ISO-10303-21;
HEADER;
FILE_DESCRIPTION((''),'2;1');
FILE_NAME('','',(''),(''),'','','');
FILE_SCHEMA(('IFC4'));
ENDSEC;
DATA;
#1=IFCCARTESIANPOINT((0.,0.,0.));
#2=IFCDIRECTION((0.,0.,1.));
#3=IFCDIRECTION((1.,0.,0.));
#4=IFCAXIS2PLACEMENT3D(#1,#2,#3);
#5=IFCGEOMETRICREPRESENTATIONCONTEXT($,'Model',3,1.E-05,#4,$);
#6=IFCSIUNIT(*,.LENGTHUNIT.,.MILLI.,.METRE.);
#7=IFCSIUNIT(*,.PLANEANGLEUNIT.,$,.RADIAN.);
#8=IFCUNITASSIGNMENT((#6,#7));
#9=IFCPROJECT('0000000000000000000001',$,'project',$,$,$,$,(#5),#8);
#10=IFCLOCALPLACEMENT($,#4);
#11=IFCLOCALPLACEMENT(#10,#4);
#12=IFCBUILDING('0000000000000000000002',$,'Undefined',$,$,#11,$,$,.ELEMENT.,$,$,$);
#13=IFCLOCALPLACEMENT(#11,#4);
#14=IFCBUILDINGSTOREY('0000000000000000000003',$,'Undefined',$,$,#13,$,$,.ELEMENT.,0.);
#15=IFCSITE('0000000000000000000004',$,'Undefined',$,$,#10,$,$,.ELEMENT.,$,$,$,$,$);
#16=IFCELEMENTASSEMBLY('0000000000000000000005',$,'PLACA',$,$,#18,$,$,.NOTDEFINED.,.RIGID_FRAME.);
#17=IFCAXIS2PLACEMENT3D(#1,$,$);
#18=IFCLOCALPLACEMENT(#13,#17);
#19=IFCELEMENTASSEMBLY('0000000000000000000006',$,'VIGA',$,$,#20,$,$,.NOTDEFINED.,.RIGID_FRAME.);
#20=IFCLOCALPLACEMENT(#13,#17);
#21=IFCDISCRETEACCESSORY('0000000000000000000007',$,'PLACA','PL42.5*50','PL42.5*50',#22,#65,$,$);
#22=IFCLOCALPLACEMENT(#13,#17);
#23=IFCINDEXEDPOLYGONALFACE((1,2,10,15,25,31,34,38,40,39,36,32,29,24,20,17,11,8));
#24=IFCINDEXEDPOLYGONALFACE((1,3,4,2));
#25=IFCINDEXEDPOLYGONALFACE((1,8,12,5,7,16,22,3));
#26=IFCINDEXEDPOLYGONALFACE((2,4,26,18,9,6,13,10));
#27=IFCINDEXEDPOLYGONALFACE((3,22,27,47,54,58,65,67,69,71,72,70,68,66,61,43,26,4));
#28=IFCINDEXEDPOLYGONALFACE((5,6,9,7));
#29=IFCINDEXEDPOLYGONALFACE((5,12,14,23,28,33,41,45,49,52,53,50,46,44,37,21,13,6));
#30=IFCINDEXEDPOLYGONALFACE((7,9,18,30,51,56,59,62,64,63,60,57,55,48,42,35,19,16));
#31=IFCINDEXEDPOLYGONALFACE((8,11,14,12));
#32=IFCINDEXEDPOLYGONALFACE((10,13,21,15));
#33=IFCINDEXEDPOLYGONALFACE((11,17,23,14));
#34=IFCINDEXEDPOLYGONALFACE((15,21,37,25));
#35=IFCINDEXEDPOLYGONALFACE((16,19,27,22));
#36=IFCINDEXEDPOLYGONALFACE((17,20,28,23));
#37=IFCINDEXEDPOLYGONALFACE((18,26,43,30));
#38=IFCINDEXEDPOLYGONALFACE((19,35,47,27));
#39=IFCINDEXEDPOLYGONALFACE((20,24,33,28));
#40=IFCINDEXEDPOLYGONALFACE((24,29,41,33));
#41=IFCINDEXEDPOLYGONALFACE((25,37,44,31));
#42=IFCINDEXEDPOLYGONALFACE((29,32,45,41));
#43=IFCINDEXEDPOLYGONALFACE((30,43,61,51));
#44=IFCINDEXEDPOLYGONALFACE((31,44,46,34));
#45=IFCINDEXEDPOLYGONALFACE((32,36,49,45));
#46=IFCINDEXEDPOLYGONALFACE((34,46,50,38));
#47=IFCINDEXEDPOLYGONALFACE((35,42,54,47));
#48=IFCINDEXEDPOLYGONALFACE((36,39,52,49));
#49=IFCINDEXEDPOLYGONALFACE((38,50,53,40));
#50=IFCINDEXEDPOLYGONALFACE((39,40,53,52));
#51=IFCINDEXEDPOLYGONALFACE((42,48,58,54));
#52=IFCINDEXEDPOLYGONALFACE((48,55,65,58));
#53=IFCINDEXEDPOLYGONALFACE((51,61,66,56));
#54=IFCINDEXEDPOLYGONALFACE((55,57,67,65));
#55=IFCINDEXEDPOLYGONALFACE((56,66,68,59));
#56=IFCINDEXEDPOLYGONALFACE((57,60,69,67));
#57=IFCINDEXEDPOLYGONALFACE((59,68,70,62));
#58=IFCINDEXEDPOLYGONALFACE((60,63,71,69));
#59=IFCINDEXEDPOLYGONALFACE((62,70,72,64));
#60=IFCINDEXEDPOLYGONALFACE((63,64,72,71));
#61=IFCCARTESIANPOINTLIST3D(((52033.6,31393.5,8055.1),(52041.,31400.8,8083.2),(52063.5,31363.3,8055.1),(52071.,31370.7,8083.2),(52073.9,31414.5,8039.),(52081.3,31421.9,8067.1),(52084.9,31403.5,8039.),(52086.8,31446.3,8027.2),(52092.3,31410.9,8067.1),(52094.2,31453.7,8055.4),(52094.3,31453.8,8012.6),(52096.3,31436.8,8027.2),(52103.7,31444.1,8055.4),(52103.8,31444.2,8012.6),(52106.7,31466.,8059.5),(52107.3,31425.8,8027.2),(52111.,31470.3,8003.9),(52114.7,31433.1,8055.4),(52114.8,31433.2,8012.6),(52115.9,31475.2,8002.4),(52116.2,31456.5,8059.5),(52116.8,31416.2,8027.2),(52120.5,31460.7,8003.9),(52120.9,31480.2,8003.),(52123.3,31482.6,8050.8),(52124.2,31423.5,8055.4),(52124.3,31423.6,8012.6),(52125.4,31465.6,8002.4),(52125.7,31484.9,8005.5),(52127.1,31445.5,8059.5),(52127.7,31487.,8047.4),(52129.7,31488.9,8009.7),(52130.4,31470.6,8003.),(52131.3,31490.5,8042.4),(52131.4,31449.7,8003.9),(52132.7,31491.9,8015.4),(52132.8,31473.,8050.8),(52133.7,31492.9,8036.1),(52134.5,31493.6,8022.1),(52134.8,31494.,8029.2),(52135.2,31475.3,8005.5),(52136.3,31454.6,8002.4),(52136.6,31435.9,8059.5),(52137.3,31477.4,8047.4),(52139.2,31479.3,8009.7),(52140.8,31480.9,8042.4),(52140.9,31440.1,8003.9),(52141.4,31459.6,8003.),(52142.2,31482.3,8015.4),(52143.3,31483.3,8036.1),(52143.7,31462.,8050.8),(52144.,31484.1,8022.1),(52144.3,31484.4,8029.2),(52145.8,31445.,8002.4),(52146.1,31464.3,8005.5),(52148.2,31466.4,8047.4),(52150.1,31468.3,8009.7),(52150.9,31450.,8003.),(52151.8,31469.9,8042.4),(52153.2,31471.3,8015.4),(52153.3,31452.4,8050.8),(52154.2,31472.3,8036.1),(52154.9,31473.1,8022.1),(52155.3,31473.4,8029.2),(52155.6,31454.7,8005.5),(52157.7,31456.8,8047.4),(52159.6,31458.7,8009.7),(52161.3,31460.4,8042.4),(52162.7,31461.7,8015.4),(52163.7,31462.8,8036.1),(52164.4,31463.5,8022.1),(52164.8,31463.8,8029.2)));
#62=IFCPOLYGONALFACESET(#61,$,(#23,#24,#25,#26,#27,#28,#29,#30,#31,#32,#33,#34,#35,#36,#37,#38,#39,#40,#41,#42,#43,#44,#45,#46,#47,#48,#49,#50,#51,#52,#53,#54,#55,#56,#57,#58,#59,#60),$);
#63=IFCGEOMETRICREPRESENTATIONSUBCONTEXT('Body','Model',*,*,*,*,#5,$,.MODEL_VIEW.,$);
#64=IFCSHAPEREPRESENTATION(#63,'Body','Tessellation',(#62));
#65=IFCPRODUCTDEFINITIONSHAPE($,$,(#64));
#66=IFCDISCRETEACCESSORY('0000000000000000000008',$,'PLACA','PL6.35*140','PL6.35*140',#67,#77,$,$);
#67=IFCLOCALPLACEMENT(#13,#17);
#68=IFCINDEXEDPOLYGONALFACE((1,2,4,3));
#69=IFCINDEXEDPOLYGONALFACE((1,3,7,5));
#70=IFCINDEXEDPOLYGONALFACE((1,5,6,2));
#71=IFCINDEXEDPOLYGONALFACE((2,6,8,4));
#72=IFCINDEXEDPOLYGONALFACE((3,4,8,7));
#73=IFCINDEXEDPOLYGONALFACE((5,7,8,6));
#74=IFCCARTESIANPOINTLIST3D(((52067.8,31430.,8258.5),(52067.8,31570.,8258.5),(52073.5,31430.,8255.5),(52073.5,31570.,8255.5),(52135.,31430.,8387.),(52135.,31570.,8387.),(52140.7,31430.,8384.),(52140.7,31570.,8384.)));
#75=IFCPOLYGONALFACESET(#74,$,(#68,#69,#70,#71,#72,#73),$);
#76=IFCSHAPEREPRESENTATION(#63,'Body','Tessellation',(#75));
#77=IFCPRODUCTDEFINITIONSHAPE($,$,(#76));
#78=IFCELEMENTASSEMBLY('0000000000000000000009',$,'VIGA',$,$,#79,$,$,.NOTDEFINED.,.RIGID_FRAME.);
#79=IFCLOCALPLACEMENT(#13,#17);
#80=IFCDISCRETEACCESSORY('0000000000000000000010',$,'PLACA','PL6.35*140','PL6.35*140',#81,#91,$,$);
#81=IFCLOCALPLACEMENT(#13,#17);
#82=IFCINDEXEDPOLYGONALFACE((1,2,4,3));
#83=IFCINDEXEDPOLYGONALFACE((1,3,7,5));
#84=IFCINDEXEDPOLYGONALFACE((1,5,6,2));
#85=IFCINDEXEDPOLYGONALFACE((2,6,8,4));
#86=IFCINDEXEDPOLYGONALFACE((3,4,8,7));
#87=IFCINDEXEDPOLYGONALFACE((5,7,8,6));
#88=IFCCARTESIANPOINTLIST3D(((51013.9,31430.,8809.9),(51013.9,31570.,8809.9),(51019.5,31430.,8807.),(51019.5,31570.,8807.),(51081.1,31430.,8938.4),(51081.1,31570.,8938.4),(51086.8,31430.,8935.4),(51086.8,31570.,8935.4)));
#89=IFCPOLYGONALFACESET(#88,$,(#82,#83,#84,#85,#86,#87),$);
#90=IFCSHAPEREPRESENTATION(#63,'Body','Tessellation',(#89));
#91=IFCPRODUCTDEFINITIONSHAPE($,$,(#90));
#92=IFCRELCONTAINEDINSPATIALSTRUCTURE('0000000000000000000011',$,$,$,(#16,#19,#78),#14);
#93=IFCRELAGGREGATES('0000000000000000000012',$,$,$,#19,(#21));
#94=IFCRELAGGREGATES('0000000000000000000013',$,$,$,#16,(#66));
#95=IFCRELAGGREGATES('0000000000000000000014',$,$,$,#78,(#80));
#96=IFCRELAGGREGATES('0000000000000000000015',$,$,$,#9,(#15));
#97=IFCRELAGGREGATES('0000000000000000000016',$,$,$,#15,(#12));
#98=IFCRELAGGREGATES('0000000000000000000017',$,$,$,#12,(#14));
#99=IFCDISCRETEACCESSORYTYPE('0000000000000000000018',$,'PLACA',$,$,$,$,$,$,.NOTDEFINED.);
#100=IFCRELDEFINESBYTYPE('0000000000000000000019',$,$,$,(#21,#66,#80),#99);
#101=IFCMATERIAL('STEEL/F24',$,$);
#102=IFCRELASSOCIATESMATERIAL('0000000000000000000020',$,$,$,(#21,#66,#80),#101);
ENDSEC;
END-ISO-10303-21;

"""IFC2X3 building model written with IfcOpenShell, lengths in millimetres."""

from ifc_helpers import new_model, si_unit, frame, frame_2d, origin_with_axes, origin_2d_with_axis, place, context, subcontext, project, spatial, polyline, circle_curve, parameter, trimmed, segment, composite_curve, rectangle, outline, extrude, boolean, material, type_object, element, aggregate, save


model = new_model("IFC2X3")

# Units and contexts
model_context = context("Model", 3, precision=1e-05, world=origin_with_axes())
body_context = subcontext(model_context, "Body", "Model", "MODEL_VIEW")
ifc_project = project(units=[si_unit("LENGTHUNIT", "METRE", prefix="MILLI"), si_unit("PLANEANGLEUNIT", "RADIAN")], contexts=[model_context])

# Site, building, storey
site_placement = place(None, origin_with_axes())
site = spatial("IfcSite", under=ifc_project, at=site_placement, Name="Undefined", CompositionType="ELEMENT")
building_placement = place(site_placement, origin_with_axes())
building = spatial("IfcBuilding", under=site, at=building_placement, Name="Undefined", CompositionType="ELEMENT")
storey_placement = place(building_placement, origin_with_axes())
storey = spatial("IfcBuildingStorey", under=building, at=storey_placement, Name="Undefined", CompositionType="ELEMENT", Elevation=0.0)

# Shared definitions
ifc_material_1 = material(Name="STEEL/F24")

# Element assembly
assembly_1_placement = place(storey_placement, origin_with_axes())
assembly_1 = element("IfcElementAssembly", 1, at=assembly_1_placement, inside=storey, Name="PLACA", AssemblyPlace="NOTDEFINED", PredefinedType="RIGID_FRAME")
discrete_accessory_type_1 = type_object("IfcDiscreteAccessoryType", Name="PLACA")

# Element assembly, discrete accessory
assembly_2_placement = place(storey_placement, origin_with_axes())
assembly_2 = element("IfcElementAssembly", 2, at=assembly_2_placement, inside=storey, Name="VIGA", AssemblyPlace="NOTDEFINED", PredefinedType="RIGID_FRAME")
discrete_accessory_1_placement = place(assembly_2_placement, frame((52154.9, 31484.0, 8042.1), z_axis=(-0.704562, 0.709643, 0.0), x_axis=(-0.247001, -0.245233, -0.937471)))
discrete_accessory_1 = element("IfcDiscreteAccessory", 3, at=discrete_accessory_1_placement, type_object=discrete_accessory_type_1, material=ifc_material_1, Name="PLACA", Description="PL42.5*50", ObjectType="PL42.5*50", context=body_context, shape_type="CSG", body=[
    boolean("DIFFERENCE", extrude(outline(composite_curve([segment(trimmed(circle_curve(frame_2d((25.0, 25.0), x_axis=(-1.0, 0.0)), 25.0), [parameter(0.0)], [parameter(1.570796)], True, "PARAMETER"), True, "CONTINUOUS"), segment(polyline([(25.0, 0.0), (25.0, 0.0)]), True, "CONTINUOUS"), segment(trimmed(circle_curve(frame_2d((25.0, 25.0), x_axis=(0.0, -1.0)), 25.0), [parameter(0.0)], [parameter(1.570796)], True, "PARAMETER"), True, "CONTINUOUS"), segment(polyline([(50.0, 25.0), (50.0, 50.0), (40.0, 65.0), (40.0, 145.0), (10.0, 145.0), (10.0, 65.0), (0.0, 50.0), (0.0, 25.0)]), True, "CONTINUOUS")], self_intersect=True)), frame((0.0, 0.0, -21.2), z_axis=(0.0, 0.0, 1.0), x_axis=(1.0, 0.0, 0.0)), (0.0, 0.0, 1.0), 42.5), extrude(rectangle(XDim=15.5, YDim=60.0, at=origin_2d_with_axis()), frame((25.0, 98.7, 0.0), z_axis=(0.0, -1.0, 0.0), x_axis=(0.0, 0.0, -1.0)), (0.0, 0.0, 1.0), 108.7)),
])
aggregate(assembly_2, [discrete_accessory_1])

# Discrete accessory
discrete_accessory_2_placement = place(assembly_1_placement, frame((52137.9, 31570.0, 8385.5), z_axis=(0.886042, 0.0, -0.463605), x_axis=(0.0, -1.0, 0.0)))
discrete_accessory_2 = element("IfcDiscreteAccessory", 4, at=discrete_accessory_2_placement, type_object=discrete_accessory_type_1, material=ifc_material_1, Name="PLACA", Description="PL6.35*140", ObjectType="PL6.35*140", context=body_context, shape_type="SweptSolid", body=[
    extrude(outline(polyline([(0.0, 0.0), (140.0, 0.0), (140.0, 145.0), (0.0, 145.0), (0.0, 0.0)])), frame((0.0, 0.0, -3.2), z_axis=(0.0, 0.0, 1.0), x_axis=(1.0, 0.0, 0.0)), (0.0, 0.0, 1.0), 6.4),
])

# Element assembly, discrete accessory
assembly_3_placement = place(storey_placement, origin_with_axes())
assembly_3 = element("IfcElementAssembly", 5, at=assembly_3_placement, inside=storey, Name="VIGA", AssemblyPlace="NOTDEFINED", PredefinedType="RIGID_FRAME")
discrete_accessory_3_placement = place(assembly_3_placement, frame((51083.9, 31570.0, 8936.9), z_axis=(0.886042, 0.0, -0.463605), x_axis=(0.0, -1.0, 0.0)))
discrete_accessory_3 = element("IfcDiscreteAccessory", 6, at=discrete_accessory_3_placement, type_object=discrete_accessory_type_1, material=ifc_material_1, Name="PLACA", Description="PL6.35*140", ObjectType="PL6.35*140", context=body_context, shape_type="SweptSolid", body=[
    extrude(outline(polyline([(0.0, 0.0), (140.0, 0.0), (140.0, 145.0), (0.0, 145.0), (0.0, 0.0)])), frame((0.0, 0.0, -3.2), z_axis=(0.0, 0.0, 1.0), x_axis=(1.0, 0.0, 0.0)), (0.0, 0.0, 1.0), 6.4),
])

aggregate(assembly_1, [discrete_accessory_2])
aggregate(assembly_3, [discrete_accessory_3])

save(model, "model.ifc")
